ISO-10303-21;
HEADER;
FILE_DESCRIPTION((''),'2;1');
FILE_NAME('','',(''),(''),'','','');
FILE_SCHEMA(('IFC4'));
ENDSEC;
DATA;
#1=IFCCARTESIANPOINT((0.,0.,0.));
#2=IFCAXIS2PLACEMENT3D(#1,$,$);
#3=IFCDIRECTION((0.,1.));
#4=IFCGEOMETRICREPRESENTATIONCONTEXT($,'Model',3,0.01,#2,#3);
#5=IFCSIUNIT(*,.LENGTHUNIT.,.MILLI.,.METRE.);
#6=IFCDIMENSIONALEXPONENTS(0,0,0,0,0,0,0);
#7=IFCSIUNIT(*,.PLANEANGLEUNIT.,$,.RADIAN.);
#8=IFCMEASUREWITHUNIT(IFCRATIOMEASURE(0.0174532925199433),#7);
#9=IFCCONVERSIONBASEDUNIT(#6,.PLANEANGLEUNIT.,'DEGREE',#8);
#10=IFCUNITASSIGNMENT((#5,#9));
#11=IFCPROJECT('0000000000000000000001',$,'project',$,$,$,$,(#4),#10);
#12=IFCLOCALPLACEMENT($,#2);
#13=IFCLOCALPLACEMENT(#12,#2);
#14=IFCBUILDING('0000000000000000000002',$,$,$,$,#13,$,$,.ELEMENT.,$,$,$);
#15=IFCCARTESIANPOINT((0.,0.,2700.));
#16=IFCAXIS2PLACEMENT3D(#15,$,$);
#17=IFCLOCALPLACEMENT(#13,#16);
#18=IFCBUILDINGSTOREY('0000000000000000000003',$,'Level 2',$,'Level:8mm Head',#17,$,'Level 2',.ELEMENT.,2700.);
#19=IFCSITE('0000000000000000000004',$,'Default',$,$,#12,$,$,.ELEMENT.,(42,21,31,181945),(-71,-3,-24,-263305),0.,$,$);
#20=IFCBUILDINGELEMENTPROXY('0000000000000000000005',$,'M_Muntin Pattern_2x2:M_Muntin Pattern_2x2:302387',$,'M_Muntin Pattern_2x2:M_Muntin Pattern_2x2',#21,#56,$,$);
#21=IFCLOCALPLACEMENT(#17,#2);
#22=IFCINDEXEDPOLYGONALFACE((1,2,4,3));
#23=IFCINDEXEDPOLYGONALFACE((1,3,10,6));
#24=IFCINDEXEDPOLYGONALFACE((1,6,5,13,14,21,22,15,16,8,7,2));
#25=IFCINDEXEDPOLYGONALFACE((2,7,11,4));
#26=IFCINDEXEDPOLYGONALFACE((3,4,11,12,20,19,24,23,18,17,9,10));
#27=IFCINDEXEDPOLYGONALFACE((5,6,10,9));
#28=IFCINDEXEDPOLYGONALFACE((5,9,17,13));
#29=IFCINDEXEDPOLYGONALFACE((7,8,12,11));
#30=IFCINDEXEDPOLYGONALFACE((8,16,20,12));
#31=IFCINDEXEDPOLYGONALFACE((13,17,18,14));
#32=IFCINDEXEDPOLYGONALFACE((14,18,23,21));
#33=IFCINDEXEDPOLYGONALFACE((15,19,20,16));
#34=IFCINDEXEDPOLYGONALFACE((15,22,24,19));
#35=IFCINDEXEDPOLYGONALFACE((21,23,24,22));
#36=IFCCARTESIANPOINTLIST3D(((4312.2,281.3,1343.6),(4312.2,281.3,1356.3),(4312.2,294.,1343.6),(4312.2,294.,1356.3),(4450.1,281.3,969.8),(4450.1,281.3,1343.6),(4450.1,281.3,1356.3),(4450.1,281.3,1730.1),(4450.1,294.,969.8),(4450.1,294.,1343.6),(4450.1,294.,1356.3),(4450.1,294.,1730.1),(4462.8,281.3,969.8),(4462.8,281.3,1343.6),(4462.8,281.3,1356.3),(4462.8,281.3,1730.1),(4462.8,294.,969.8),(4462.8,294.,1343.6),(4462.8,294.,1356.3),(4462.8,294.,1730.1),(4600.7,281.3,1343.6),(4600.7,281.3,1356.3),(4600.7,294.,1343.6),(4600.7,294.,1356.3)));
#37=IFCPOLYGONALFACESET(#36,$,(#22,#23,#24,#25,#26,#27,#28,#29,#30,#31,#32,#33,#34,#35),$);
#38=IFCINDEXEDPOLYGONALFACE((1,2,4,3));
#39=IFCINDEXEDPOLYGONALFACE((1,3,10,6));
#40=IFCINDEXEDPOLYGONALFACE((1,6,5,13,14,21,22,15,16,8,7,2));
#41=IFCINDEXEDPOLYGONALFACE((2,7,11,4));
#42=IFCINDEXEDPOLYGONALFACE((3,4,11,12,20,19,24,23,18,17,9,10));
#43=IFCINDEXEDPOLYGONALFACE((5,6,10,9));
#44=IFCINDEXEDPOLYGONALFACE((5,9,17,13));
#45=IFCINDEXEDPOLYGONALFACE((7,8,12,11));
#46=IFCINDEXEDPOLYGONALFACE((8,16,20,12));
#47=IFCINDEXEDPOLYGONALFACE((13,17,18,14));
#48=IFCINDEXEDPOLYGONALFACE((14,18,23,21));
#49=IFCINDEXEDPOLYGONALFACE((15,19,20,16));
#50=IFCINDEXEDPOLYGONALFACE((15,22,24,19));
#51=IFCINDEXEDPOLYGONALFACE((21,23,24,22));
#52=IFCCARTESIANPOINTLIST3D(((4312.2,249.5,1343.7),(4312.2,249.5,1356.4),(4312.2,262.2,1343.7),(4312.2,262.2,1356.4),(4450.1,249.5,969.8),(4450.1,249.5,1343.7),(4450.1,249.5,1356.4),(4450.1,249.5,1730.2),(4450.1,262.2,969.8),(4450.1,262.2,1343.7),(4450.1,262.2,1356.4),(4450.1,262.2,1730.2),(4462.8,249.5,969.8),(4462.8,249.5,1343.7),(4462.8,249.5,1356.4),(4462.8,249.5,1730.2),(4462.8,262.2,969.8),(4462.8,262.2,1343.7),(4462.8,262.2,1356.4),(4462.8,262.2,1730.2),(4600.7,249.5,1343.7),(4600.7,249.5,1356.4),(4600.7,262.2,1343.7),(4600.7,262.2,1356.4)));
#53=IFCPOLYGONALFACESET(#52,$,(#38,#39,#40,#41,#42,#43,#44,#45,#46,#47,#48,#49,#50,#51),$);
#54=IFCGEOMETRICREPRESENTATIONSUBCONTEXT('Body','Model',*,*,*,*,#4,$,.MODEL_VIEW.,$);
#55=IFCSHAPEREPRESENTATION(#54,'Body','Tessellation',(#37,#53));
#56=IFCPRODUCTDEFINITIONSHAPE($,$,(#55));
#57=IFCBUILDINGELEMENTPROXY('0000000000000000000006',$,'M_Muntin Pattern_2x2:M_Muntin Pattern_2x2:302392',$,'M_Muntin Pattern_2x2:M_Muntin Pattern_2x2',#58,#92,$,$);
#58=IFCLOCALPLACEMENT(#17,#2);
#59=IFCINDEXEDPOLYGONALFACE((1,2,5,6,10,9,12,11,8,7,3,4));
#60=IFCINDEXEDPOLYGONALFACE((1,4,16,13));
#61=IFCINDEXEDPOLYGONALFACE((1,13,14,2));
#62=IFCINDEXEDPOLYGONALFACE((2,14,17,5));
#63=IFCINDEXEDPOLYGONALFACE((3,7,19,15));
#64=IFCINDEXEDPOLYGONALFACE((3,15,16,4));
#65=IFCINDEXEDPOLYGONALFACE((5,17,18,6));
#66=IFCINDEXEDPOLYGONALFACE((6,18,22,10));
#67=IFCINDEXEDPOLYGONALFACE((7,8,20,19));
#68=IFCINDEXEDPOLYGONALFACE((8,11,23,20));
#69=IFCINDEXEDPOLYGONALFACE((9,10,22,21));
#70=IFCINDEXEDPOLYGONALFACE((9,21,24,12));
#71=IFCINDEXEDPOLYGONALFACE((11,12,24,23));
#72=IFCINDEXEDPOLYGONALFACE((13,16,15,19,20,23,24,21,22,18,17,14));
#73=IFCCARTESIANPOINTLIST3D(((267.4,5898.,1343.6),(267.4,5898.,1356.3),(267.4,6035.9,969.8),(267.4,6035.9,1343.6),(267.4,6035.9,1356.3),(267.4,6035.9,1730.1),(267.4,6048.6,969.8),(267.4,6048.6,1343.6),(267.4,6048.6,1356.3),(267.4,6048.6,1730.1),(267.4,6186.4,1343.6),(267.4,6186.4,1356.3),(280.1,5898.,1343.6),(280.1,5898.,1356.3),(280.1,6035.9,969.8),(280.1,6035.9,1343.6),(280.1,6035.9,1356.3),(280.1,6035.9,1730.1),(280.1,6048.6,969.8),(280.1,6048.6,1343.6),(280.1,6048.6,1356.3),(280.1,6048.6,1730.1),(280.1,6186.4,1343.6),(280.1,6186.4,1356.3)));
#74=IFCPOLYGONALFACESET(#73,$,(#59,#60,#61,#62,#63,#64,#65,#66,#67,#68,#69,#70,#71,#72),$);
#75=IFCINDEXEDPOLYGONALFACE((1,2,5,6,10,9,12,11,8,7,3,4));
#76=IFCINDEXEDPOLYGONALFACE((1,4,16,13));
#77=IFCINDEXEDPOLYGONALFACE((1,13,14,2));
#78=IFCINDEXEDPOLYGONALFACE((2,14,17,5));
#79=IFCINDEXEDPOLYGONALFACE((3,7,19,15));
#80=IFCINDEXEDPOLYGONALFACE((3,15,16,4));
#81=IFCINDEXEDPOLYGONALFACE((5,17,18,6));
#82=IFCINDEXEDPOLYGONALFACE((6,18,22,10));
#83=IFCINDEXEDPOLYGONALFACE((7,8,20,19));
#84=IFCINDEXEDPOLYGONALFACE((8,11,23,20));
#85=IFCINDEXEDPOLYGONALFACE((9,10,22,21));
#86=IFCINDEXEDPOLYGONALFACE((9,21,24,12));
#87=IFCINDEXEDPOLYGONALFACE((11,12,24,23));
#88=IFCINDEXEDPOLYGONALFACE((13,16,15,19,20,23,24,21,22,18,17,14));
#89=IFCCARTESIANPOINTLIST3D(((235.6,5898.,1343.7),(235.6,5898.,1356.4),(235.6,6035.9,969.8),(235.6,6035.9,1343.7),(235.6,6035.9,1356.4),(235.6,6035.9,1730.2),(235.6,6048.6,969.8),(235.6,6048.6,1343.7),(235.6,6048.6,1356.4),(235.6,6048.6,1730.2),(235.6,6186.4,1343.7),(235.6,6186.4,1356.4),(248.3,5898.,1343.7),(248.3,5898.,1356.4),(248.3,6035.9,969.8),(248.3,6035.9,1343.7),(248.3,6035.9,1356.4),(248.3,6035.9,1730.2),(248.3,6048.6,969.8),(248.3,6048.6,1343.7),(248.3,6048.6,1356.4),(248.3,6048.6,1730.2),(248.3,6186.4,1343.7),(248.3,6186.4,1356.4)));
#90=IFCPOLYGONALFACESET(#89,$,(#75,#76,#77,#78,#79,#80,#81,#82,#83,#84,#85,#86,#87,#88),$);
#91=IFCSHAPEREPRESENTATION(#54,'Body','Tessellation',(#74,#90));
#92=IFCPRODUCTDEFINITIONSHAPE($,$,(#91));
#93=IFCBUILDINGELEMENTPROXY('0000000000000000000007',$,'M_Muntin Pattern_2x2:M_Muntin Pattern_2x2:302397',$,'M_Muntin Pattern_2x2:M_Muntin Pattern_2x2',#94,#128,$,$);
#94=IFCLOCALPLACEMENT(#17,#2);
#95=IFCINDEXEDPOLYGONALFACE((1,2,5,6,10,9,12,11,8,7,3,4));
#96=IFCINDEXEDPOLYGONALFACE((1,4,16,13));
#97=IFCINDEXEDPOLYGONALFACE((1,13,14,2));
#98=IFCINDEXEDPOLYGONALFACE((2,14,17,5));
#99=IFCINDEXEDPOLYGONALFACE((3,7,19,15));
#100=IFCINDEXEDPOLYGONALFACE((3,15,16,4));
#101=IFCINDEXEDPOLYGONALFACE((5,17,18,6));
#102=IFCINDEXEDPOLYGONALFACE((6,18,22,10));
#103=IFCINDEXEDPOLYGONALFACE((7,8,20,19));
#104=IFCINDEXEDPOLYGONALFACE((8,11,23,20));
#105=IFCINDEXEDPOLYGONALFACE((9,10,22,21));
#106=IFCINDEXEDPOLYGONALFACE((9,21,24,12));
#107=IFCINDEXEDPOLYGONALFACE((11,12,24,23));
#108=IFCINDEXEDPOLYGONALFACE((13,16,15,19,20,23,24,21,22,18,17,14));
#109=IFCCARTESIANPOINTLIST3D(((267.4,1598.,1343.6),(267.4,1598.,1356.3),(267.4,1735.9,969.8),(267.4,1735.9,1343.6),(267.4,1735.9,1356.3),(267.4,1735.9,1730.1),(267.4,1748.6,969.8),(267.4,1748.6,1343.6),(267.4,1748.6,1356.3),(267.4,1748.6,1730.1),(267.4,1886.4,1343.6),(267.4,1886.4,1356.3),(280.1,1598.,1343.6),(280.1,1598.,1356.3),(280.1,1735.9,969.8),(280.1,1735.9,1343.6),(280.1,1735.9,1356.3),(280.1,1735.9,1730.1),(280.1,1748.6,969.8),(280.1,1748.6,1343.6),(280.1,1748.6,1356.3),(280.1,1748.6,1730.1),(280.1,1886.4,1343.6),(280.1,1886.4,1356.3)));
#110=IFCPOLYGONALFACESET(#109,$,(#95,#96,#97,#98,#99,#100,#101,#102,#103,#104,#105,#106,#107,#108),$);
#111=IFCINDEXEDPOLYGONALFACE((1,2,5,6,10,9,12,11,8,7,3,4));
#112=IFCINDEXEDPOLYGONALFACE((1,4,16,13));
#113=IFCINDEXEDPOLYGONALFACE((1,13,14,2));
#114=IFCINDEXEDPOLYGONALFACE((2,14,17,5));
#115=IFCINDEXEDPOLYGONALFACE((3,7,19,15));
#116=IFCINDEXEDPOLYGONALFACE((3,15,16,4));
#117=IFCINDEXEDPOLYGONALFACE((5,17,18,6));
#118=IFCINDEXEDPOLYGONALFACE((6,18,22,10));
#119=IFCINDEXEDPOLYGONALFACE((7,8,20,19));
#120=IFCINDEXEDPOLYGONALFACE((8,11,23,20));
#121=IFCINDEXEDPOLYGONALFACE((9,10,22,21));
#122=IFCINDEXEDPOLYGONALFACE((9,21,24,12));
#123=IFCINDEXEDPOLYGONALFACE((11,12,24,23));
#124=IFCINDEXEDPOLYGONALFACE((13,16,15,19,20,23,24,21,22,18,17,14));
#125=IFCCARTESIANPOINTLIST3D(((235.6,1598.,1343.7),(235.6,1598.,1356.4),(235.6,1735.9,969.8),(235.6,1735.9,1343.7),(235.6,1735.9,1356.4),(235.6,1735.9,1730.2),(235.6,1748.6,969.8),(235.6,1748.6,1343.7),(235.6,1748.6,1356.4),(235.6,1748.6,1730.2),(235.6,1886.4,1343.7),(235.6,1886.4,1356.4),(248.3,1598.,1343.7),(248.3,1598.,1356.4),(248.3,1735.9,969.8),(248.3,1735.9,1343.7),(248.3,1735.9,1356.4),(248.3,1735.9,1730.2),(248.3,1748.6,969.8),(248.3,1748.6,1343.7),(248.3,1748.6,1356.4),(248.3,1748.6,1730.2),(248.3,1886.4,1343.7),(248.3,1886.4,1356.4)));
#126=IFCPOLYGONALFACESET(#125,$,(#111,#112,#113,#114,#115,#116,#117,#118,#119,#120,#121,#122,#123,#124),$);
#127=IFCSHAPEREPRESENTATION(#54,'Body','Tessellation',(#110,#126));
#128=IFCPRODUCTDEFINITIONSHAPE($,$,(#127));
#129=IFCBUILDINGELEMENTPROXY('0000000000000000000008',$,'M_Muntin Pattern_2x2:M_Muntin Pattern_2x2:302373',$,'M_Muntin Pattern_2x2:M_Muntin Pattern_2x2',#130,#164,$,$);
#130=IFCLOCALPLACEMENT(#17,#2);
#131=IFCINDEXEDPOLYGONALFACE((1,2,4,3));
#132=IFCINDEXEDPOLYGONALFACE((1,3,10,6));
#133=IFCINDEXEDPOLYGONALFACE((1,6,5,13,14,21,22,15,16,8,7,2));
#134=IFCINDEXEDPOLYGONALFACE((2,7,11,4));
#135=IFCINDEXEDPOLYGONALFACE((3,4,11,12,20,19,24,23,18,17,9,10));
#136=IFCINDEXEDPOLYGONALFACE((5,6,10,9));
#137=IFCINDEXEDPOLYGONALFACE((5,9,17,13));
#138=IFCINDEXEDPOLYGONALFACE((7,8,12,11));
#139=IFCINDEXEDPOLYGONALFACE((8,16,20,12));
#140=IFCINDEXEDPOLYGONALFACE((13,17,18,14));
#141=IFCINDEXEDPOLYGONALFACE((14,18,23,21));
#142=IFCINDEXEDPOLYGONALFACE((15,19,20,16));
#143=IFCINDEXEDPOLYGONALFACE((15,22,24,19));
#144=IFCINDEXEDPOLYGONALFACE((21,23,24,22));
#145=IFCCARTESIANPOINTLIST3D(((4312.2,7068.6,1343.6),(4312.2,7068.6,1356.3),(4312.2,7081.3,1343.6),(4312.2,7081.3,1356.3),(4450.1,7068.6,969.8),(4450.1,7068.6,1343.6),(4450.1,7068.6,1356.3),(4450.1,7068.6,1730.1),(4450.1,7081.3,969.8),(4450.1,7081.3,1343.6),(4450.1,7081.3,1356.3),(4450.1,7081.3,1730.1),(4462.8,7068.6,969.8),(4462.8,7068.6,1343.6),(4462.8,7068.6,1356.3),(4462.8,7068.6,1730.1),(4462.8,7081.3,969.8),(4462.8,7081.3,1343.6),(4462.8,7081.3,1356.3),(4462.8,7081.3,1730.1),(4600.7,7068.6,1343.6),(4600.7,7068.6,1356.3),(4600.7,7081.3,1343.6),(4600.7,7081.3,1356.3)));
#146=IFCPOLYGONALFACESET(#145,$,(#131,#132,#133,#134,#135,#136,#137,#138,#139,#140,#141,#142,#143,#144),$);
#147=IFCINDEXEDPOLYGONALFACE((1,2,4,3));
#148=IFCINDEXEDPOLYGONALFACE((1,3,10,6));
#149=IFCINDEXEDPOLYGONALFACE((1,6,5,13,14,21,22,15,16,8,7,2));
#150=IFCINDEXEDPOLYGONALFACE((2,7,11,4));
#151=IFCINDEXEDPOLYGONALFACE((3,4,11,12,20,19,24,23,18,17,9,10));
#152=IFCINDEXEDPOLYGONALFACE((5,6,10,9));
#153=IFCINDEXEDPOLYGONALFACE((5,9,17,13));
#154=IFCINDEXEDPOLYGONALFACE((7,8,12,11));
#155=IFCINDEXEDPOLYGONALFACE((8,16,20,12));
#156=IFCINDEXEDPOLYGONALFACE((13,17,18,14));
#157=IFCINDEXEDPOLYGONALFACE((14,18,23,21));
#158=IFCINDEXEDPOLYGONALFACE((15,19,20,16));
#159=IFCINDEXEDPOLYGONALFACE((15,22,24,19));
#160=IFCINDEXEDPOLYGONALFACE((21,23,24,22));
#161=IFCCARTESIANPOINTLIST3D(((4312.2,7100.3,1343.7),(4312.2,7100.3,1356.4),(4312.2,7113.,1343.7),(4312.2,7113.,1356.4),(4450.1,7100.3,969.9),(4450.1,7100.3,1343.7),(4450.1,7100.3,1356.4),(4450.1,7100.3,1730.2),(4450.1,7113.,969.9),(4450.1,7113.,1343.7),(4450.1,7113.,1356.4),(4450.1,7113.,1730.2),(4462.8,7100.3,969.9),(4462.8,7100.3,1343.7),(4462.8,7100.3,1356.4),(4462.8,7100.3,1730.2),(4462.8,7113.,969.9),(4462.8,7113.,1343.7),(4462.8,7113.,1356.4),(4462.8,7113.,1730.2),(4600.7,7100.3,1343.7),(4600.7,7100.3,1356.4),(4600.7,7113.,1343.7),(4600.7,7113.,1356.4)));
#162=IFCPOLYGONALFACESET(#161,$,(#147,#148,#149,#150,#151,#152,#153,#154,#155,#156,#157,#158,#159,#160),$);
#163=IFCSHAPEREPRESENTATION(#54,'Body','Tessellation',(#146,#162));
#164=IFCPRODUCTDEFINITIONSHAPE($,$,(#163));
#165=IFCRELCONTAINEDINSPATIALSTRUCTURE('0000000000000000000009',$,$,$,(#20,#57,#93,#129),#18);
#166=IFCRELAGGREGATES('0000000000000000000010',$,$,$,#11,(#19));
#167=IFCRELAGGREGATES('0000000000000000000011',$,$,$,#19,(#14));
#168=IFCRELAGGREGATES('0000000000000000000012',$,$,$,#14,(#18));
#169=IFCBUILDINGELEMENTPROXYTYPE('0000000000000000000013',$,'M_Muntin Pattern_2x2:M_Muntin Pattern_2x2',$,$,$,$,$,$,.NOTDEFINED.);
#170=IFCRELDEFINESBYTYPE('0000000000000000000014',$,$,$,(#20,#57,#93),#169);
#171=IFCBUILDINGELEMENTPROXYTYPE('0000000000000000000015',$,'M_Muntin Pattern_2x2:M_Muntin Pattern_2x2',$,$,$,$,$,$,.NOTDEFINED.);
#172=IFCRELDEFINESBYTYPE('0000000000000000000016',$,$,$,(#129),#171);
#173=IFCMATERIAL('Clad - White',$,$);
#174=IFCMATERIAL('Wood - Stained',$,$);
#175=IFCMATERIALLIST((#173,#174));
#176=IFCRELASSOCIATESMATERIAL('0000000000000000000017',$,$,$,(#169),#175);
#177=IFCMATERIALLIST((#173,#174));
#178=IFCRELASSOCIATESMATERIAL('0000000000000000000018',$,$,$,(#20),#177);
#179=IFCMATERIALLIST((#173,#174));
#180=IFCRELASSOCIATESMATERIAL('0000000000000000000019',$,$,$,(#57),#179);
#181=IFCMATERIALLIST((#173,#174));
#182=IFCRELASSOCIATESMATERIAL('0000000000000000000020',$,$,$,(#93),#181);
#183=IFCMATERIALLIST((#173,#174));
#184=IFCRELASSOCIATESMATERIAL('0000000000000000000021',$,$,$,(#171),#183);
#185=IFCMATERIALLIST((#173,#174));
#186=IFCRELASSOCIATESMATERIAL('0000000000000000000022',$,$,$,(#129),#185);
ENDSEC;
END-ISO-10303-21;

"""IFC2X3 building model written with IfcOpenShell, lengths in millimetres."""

from ifc_helpers import new_model, entity, si_unit, converted_unit, direction, frame, origin, place, context, subcontext, project, spatial, polyline, outline, extrude, source, transform, mapped, material, material_list, type_object, type_shapes, element, save


model = new_model("IFC2X3")

# Units and contexts
model_context = context("Model", 3, precision=0.01, world=origin(), true_north=direction((0.0, 1.0)))
body_context = subcontext(model_context, "Body", "Model", "MODEL_VIEW")
ifc_project = project(units=[si_unit("LENGTHUNIT", "METRE", prefix="MILLI"), converted_unit("PLANEANGLEUNIT", "DEGREE", entity("IfcRatioMeasure", 0.0174532925199433), si_unit("PLANEANGLEUNIT", "RADIAN"), dimensions=[0, 0, 0, 0, 0, 0, 0])], contexts=[model_context])

# Site, building, storey
site_placement = place(None, origin())
site = spatial("IfcSite", under=ifc_project, at=site_placement, Name="Default", CompositionType="ELEMENT", RefLatitude=(42, 21, 31, 181945), RefLongitude=(-71, -3, -24, -263305), RefElevation=0.0)
building_placement = place(site_placement, origin())
building = spatial("IfcBuilding", under=site, at=building_placement, CompositionType="ELEMENT")
storey_placement = place(building_placement, frame((0.0, 0.0, 2700.0)))
storey = spatial("IfcBuildingStorey", under=building, at=storey_placement, Name="Level 2", ObjectType="Level:8mm Head", LongName="Level 2", CompositionType="ELEMENT", Elevation=2700.0)

# Building element proxies
ifc_material_1 = material(Name="Clad - White")
ifc_material_2 = material(Name="Wood - Stained")
ifc_material_list_1 = material_list([ifc_material_1, ifc_material_2])
ifc_material_list_2 = material_list([ifc_material_1, ifc_material_2])
building_element_proxy_type_1 = type_object("IfcBuildingElementProxyType", Name="M_Muntin Pattern_2x2:M_Muntin Pattern_2x2", PredefinedType="NOTDEFINED", material=ifc_material_list_2)
shared_shape_1 = source(origin(), body_context, "Body", "SweptSolid", [
    extrude(outline(polyline([(6.4, -6.4), (380.1, -6.4), (380.1, 6.3), (6.4, 6.3), (6.4, 144.2), (-6.3, 144.2), (-6.3, 6.3), (-380.2, 6.3), (-380.2, -6.4), (-6.3, -6.4), (-6.3, -144.2), (6.4, -144.2), (6.4, -6.4)])), frame((0.0, 9.5, 380.1), z_axis=(0.0, 1.0, 0.0), x_axis=(0.0, 0.0, 1.0)), (0.0, 0.0, 1.0), 12.7),
    extrude(outline(polyline([(6.4, -6.4), (380.2, -6.4), (380.2, 6.3), (6.4, 6.3), (6.4, 144.2), (-6.3, 144.2), (-6.3, 6.3), (-380.2, 6.3), (-380.2, -6.4), (-6.3, -6.4), (-6.3, -144.2), (6.4, -144.2), (6.4, -6.4)])), frame((0.0, -22.2, 380.2), z_axis=(0.0, 1.0, 0.0), x_axis=(0.0, 0.0, 1.0)), (0.0, 0.0, 1.0), 12.7),
])
type_shapes(building_element_proxy_type_1, [shared_shape_1])
proxy_1_placement = place(storey_placement, frame((4456.5, 271.8, 969.8)))
element("IfcBuildingElementProxy", 1, at=proxy_1_placement, inside=storey, type_object=building_element_proxy_type_1, material=ifc_material_list_1, Name="M_Muntin Pattern_2x2:M_Muntin Pattern_2x2:302387", ObjectType="M_Muntin Pattern_2x2:M_Muntin Pattern_2x2", context=body_context, shape_type="MappedRepresentation", body=[
    mapped(shared_shape_1, transform((0.0, 0.0, 0.0), scale=1.0)),
])
ifc_material_list_3 = material_list([ifc_material_1, ifc_material_2])
proxy_2_placement = place(storey_placement, frame((257.9, 6042.2, 969.8), z_axis=(0.0, 0.0, 1.0), x_axis=(0.0, -1.0, 0.0)))
element("IfcBuildingElementProxy", 2, at=proxy_2_placement, inside=storey, type_object=building_element_proxy_type_1, material=ifc_material_list_3, Name="M_Muntin Pattern_2x2:M_Muntin Pattern_2x2:302392", ObjectType="M_Muntin Pattern_2x2:M_Muntin Pattern_2x2", context=body_context, shape_type="MappedRepresentation", body=[
    mapped(shared_shape_1, transform((0.0, 0.0, 0.0), scale=1.0)),
])
ifc_material_list_4 = material_list([ifc_material_1, ifc_material_2])
proxy_3_placement = place(storey_placement, frame((257.9, 1742.2, 969.8), z_axis=(0.0, 0.0, 1.0), x_axis=(0.0, -1.0, 0.0)))
element("IfcBuildingElementProxy", 3, at=proxy_3_placement, inside=storey, type_object=building_element_proxy_type_1, material=ifc_material_list_4, Name="M_Muntin Pattern_2x2:M_Muntin Pattern_2x2:302397", ObjectType="M_Muntin Pattern_2x2:M_Muntin Pattern_2x2", context=body_context, shape_type="MappedRepresentation", body=[
    mapped(shared_shape_1, transform((0.0, 0.0, 0.0), scale=1.0)),
])
ifc_material_list_5 = material_list([ifc_material_1, ifc_material_2])
ifc_material_list_6 = material_list([ifc_material_1, ifc_material_2])
building_element_proxy_type_2 = type_object("IfcBuildingElementProxyType", Name="M_Muntin Pattern_2x2:M_Muntin Pattern_2x2", PredefinedType="NOTDEFINED", material=ifc_material_list_6)
shared_shape_2 = source(origin(), body_context, "Body", "SweptSolid", [
    extrude(outline(polyline([(6.4, -6.4), (380.1, -6.4), (380.1, 6.3), (6.4, 6.3), (6.4, 144.2), (-6.3, 144.2), (-6.3, 6.3), (-380.2, 6.3), (-380.2, -6.4), (-6.3, -6.4), (-6.3, -144.2), (6.4, -144.2), (6.4, -6.4)])), frame((0.0, -22.2, 380.1), z_axis=(0.0, 1.0, 0.0), x_axis=(0.0, 0.0, 1.0)), (0.0, 0.0, 1.0), 12.7),
    extrude(outline(polyline([(6.4, -6.4), (380.2, -6.4), (380.2, 6.3), (6.4, 6.3), (6.4, 144.2), (-6.3, 144.2), (-6.3, 6.3), (-380.2, 6.3), (-380.2, -6.4), (-6.3, -6.4), (-6.3, -144.2), (6.4, -144.2), (6.4, -6.4)])), frame((0.0, 9.5, 380.2), z_axis=(0.0, 1.0, 0.0), x_axis=(0.0, 0.0, 1.0)), (0.0, 0.0, 1.0), 12.7),
])
type_shapes(building_element_proxy_type_2, [shared_shape_2])
proxy_4_placement = place(storey_placement, frame((4456.5, 7090.8, 969.9)))
element("IfcBuildingElementProxy", 4, at=proxy_4_placement, inside=storey, type_object=building_element_proxy_type_2, material=ifc_material_list_5, Name="M_Muntin Pattern_2x2:M_Muntin Pattern_2x2:302373", ObjectType="M_Muntin Pattern_2x2:M_Muntin Pattern_2x2", context=body_context, shape_type="MappedRepresentation", body=[
    mapped(shared_shape_2, transform((0.0, 0.0, 0.0), scale=1.0)),
])

save(model, "model.ifc")
